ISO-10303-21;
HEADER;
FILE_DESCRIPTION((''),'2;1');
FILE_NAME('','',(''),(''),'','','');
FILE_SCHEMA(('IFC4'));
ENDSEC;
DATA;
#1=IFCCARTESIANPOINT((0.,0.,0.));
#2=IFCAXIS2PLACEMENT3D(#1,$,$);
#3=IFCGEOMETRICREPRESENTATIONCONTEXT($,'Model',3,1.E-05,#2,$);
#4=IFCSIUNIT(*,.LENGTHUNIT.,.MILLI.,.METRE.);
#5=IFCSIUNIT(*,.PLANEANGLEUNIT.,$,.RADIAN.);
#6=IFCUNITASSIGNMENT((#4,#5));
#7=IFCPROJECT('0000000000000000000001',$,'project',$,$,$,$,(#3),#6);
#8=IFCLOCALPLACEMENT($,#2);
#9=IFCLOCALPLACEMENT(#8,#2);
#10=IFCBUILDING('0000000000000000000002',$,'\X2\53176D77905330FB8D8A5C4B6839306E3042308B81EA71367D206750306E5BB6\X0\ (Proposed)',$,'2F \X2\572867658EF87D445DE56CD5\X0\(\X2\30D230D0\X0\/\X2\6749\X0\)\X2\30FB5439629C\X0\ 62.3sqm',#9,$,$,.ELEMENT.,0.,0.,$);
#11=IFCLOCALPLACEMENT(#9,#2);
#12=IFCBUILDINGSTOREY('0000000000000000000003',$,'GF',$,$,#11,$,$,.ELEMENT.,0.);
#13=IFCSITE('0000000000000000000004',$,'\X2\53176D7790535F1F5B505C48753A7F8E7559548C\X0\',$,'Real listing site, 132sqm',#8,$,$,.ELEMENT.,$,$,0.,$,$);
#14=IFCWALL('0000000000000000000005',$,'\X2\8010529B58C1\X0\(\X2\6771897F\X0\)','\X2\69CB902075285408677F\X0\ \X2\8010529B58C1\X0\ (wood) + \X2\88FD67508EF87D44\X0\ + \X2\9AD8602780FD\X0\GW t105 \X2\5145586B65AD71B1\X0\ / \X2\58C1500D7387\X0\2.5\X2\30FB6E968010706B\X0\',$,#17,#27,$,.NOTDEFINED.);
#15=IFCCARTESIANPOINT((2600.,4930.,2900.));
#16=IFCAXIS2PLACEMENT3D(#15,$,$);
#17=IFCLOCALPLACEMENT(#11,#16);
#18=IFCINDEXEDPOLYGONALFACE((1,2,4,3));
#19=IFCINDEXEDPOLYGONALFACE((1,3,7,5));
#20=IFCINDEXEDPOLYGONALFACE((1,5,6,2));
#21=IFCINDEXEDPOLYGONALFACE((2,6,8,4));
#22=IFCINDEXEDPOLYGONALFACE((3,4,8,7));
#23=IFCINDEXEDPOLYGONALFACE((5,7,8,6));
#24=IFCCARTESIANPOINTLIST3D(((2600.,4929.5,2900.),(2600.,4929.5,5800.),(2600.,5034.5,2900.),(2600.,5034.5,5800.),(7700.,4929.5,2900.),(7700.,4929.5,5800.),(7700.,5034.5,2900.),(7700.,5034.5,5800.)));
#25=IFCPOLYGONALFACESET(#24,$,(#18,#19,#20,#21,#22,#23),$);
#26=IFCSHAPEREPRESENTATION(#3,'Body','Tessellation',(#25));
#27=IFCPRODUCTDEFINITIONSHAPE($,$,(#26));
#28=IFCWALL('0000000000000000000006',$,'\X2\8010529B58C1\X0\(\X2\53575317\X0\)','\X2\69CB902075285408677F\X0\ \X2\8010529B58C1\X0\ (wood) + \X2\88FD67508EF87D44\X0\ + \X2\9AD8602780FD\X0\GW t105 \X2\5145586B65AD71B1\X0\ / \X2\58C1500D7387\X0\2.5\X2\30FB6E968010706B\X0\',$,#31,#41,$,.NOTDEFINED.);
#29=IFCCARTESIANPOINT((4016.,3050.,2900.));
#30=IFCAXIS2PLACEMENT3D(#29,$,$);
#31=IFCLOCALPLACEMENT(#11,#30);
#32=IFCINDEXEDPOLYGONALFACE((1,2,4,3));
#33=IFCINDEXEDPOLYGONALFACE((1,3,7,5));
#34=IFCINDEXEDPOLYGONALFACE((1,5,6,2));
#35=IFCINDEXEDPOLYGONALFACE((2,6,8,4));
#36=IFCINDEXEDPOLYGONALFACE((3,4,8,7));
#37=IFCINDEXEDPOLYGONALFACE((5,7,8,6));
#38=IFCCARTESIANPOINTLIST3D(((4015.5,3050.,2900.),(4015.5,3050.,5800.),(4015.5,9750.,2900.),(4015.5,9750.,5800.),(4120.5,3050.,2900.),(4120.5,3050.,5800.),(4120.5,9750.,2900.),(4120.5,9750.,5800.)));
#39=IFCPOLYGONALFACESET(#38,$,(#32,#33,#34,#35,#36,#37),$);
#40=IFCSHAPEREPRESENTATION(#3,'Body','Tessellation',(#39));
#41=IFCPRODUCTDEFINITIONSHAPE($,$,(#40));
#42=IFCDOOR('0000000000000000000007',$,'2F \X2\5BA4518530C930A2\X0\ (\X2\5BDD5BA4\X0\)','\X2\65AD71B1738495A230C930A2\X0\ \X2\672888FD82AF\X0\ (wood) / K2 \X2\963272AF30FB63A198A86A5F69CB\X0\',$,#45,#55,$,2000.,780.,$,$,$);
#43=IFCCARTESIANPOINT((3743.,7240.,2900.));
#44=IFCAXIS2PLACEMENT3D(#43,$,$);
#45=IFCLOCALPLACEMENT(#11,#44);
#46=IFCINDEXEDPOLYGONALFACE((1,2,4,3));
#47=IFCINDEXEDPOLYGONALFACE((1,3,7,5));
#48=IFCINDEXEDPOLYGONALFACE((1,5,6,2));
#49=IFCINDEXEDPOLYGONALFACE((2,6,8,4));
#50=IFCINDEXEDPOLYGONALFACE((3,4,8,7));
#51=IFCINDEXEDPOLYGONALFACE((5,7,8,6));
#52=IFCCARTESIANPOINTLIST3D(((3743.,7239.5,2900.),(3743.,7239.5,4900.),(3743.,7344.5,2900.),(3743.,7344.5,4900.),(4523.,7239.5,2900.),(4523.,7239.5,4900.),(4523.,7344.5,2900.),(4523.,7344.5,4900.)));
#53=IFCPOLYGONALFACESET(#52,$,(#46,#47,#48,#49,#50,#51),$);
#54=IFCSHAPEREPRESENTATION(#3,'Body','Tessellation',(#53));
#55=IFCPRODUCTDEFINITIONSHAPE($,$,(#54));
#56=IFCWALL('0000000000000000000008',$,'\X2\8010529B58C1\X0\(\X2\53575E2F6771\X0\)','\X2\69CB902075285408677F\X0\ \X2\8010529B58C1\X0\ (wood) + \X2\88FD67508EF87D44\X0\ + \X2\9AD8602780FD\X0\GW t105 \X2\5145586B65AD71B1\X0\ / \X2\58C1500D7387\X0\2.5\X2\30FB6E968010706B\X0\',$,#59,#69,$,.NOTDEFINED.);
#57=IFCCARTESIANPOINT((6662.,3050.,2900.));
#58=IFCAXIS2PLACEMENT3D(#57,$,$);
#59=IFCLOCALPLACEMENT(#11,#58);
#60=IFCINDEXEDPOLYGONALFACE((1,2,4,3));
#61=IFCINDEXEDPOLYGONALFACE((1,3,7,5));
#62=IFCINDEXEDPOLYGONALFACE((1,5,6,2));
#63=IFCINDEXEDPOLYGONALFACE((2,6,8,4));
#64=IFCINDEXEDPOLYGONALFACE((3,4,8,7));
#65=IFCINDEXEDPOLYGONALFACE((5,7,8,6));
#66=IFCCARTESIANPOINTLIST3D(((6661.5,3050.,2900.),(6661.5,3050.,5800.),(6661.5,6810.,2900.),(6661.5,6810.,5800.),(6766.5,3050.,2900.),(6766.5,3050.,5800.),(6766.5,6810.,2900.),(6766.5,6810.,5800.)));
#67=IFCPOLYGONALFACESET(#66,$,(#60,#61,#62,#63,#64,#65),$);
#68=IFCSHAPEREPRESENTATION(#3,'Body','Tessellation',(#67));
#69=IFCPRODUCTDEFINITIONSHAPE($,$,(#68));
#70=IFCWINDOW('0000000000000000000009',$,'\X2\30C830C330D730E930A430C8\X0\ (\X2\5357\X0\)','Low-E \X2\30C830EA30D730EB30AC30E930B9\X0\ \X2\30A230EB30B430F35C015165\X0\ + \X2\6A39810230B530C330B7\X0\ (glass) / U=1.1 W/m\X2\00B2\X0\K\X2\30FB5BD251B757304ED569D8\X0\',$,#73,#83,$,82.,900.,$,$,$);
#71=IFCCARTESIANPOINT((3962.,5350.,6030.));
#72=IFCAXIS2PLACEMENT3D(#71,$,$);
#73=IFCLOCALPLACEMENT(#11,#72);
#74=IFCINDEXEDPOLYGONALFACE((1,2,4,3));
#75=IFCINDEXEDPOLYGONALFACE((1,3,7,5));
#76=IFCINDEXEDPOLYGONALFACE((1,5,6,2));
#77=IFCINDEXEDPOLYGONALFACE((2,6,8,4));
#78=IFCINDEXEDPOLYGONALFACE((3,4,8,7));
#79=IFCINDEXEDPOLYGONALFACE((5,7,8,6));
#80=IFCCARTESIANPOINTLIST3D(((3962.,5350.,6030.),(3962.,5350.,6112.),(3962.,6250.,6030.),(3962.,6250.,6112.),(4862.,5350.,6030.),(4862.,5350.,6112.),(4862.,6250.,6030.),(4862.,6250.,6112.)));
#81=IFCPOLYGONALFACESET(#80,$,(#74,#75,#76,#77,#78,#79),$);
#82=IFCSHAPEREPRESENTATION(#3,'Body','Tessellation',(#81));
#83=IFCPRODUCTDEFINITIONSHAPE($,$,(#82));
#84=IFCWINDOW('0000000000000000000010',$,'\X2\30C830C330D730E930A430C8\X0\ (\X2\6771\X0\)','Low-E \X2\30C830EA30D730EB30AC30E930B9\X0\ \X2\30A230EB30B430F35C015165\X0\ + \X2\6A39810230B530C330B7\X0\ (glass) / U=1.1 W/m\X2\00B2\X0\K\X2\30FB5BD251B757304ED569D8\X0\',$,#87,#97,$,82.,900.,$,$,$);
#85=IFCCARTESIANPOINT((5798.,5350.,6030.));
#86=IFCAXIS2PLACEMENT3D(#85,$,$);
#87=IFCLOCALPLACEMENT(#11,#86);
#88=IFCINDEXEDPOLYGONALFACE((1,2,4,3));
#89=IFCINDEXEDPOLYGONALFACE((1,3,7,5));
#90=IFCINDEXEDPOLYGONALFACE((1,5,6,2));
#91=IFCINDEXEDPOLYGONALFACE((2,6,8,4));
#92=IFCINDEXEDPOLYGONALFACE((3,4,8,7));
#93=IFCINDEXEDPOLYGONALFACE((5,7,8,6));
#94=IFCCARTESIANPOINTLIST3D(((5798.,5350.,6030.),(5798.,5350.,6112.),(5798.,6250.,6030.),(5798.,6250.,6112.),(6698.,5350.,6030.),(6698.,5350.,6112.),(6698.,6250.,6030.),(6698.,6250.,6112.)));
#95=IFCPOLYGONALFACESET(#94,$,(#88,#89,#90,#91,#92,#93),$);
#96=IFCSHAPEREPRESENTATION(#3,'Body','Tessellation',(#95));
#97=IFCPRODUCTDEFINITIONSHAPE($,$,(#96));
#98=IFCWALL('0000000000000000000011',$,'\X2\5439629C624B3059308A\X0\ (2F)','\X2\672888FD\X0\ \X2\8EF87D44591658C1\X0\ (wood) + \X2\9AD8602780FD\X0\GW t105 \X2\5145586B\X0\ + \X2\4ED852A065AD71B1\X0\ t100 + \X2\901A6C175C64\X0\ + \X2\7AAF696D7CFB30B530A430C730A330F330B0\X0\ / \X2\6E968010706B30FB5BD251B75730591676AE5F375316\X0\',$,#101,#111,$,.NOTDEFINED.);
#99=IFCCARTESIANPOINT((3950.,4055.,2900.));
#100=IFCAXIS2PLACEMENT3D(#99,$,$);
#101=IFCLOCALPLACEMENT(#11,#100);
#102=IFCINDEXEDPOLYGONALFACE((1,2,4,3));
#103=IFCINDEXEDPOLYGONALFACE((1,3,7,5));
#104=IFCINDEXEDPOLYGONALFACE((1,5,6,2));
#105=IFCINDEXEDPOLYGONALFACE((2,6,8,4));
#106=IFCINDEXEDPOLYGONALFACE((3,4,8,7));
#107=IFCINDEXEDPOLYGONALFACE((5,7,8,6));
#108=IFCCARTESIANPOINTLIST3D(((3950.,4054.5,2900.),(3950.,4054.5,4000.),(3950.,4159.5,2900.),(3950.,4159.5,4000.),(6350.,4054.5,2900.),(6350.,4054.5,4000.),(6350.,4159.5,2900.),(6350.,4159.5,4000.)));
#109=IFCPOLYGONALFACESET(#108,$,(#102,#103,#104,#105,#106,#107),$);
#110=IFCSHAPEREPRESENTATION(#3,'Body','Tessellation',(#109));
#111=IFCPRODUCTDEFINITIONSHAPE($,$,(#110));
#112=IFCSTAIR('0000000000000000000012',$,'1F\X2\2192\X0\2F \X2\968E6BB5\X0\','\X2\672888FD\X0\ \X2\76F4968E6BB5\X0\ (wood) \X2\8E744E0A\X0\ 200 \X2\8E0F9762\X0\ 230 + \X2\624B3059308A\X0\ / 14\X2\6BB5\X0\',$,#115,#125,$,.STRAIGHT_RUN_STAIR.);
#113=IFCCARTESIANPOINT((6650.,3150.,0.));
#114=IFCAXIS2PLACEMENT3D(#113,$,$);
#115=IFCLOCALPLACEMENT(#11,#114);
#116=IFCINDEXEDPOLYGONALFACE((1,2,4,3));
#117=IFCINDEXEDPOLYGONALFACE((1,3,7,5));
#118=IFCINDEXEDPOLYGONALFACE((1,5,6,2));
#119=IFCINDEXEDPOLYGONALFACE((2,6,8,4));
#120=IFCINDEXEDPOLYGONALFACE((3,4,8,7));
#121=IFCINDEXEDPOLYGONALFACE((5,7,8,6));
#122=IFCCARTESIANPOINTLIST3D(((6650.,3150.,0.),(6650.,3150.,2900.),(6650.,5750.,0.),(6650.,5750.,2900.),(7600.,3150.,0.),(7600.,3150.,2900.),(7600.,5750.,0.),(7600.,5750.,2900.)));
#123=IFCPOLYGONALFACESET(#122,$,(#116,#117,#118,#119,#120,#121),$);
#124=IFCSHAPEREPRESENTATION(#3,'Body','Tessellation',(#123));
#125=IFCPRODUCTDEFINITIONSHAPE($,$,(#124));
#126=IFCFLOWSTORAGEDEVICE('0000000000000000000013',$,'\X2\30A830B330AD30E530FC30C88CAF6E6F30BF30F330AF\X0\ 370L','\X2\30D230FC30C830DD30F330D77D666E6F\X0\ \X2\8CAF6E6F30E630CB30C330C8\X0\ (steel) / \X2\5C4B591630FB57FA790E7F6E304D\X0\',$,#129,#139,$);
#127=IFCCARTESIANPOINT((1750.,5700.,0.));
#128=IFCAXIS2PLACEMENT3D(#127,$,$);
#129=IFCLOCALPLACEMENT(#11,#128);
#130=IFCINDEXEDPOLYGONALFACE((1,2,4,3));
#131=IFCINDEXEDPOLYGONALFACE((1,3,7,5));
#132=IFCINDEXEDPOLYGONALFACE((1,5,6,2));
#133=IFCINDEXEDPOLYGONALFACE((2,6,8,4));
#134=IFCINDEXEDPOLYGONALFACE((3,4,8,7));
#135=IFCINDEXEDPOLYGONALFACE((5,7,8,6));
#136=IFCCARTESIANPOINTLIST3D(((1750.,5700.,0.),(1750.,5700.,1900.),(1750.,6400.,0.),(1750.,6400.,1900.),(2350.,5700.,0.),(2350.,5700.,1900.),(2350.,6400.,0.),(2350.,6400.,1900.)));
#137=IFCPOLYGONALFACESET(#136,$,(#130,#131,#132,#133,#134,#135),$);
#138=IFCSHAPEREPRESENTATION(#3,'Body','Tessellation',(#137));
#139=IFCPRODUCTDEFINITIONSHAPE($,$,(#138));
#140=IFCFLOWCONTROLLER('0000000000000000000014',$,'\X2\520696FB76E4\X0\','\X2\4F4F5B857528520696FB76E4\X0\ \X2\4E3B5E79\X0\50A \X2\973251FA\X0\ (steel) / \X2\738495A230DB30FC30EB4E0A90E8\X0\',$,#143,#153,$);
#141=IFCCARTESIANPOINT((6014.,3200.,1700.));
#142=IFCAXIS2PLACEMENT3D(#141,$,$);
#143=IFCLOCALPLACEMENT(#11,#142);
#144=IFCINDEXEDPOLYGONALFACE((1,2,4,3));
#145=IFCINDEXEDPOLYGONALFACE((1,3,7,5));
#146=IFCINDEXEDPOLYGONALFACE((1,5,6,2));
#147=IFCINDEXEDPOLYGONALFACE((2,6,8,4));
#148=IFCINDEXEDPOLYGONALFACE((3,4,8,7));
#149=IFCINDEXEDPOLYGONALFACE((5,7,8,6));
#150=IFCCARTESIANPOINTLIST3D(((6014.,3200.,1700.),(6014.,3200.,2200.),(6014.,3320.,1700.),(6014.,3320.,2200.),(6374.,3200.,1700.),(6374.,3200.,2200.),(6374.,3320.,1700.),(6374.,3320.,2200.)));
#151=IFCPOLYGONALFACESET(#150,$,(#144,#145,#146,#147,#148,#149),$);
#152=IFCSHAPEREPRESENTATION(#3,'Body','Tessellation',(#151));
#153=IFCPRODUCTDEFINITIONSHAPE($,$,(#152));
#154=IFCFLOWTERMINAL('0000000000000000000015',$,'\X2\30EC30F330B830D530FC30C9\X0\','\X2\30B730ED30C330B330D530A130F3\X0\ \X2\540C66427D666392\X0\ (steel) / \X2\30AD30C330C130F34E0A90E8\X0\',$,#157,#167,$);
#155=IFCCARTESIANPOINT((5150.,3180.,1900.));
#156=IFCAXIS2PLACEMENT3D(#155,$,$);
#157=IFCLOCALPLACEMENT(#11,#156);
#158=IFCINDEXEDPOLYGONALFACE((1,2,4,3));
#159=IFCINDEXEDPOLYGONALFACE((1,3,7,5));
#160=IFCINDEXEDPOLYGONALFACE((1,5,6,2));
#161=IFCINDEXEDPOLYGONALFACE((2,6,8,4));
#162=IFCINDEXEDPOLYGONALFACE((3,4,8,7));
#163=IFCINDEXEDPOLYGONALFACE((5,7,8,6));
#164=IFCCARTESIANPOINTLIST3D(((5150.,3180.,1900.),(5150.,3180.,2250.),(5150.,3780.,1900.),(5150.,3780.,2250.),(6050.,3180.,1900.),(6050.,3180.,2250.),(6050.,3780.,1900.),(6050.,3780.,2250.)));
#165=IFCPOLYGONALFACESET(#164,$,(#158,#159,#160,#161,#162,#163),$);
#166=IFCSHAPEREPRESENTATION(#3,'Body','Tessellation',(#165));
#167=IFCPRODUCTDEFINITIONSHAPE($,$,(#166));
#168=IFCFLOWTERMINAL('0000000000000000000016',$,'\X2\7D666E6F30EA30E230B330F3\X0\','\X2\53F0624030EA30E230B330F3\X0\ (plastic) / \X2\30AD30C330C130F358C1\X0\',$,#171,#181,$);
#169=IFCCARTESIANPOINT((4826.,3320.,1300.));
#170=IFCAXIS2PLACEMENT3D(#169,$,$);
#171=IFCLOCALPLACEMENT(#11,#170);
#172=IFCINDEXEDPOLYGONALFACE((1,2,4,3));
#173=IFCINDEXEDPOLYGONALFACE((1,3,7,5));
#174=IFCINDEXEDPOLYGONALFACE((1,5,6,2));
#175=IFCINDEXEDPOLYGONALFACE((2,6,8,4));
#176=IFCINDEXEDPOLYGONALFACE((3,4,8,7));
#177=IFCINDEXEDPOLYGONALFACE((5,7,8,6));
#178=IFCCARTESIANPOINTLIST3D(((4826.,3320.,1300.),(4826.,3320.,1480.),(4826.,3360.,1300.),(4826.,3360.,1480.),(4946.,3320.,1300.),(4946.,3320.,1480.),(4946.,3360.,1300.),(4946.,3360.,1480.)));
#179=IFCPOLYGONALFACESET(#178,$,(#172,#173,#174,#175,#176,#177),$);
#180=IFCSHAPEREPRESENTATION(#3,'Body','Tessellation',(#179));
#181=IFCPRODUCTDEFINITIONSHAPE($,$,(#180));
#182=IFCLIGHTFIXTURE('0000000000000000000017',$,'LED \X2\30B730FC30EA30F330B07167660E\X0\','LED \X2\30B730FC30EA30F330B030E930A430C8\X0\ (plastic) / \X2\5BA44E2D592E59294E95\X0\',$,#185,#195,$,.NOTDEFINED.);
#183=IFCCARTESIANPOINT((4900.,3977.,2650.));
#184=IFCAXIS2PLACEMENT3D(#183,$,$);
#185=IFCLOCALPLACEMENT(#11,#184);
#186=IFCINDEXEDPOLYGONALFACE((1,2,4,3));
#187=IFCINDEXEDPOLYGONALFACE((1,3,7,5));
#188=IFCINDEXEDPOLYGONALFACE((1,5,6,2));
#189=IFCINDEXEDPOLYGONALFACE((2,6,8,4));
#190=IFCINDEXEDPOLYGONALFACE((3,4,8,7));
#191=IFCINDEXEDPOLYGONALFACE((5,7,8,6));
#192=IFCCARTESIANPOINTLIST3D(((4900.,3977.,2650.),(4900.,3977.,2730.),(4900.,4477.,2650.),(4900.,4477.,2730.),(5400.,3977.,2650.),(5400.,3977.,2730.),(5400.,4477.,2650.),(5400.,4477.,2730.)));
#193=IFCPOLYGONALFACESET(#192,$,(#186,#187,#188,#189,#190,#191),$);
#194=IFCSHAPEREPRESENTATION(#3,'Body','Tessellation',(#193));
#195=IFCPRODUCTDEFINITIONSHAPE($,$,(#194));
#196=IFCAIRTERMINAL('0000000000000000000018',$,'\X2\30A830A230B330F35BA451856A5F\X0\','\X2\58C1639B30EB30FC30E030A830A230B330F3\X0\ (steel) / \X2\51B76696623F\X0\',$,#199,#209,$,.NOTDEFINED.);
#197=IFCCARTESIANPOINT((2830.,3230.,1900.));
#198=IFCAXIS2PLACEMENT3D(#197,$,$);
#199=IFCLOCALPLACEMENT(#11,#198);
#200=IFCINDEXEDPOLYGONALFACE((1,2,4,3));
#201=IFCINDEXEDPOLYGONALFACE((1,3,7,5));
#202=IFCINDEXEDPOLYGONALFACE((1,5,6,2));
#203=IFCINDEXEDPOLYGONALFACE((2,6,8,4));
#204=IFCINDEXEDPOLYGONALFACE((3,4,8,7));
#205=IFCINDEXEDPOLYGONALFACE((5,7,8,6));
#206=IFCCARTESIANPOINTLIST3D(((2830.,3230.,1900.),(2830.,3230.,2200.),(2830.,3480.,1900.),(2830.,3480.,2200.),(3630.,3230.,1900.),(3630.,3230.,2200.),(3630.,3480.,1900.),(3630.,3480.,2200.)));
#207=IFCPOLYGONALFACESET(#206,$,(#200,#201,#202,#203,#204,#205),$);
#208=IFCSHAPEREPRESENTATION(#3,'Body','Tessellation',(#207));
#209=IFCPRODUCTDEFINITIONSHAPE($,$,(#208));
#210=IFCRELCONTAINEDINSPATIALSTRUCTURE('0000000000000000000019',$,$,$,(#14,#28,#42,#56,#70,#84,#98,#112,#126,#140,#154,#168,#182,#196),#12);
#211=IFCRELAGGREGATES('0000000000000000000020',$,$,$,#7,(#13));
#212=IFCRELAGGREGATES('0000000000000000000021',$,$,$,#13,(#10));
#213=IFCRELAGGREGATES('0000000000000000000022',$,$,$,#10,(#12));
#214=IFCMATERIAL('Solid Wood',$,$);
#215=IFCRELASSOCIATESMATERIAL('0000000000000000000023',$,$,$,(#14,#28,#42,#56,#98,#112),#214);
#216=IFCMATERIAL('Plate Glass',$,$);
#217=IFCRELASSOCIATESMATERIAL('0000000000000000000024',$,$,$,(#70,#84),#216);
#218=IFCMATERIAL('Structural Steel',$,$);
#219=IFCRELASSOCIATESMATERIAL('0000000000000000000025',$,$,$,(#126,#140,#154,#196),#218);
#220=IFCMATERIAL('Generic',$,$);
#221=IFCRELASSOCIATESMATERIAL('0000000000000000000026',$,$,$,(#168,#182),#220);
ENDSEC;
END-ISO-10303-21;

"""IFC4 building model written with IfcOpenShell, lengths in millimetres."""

from ifc_helpers import new_model, si_unit, frame, frame_2d, origin, place, context, project, spatial, rectangle, extrude, material, element, fill, save


model = new_model("IFC4")

# Units and contexts
model_context = context("Model", 3, precision=1e-05, world=origin())
ifc_project = project(units=[si_unit("LENGTHUNIT", "METRE", prefix="MILLI"), si_unit("PLANEANGLEUNIT", "RADIAN")], contexts=[model_context])

# Site, building, storey
site_placement = place(None, origin())
site = spatial("IfcSite", under=ifc_project, at=site_placement, Name="北海道弟子屈町美留和", ObjectType="Real listing site, 132sqm", CompositionType="ELEMENT", RefElevation=0.0)
building_placement = place(site_placement, origin())
building = spatial("IfcBuilding", under=site, at=building_placement, Name="北海道・越屋根のある自然素材の家 (Proposed)", ObjectType="2F 在来軸組工法(ヒバ/杉)・吹抜 62.3sqm", CompositionType="ELEMENT", ElevationOfRefHeight=0.0, ElevationOfTerrain=0.0)
storey_placement = place(building_placement, origin())
storey = spatial("IfcBuildingStorey", under=building, at=storey_placement, Name="GF", CompositionType="ELEMENT", Elevation=0.0)

# Shared definitions
ifc_material_1 = material(Name="Solid Wood")

# Wall
wall_1_placement = place(storey_placement, frame((2600.0, 4930.0, 2900.0)))
element("IfcWall", 1, at=wall_1_placement, inside=storey, material=ifc_material_1, Name="耐力壁(東西)", Description="構造用合板 耐力壁 (wood) + 製材軸組 + 高性能GW t105 充填断熱 / 壁倍率2.5・準耐火", PredefinedType="NOTDEFINED", context=model_context, shape_type="SweptSolid", body=[
    extrude(rectangle(XDim=5100.0, YDim=105.0, at=frame_2d((2550.0, 52.0))), frame((2600.0, 4930.0, 2900.0)), (0.0, 0.0, 1.0), 2900.0),
])

# Wall, opening, door
wall_2_placement = place(storey_placement, frame((4016.0, 3050.0, 2900.0)))
wall_2 = element("IfcWall", 2, at=wall_2_placement, inside=storey, material=ifc_material_1, Name="耐力壁(南北)", Description="構造用合板 耐力壁 (wood) + 製材軸組 + 高性能GW t105 充填断熱 / 壁倍率2.5・準耐火", PredefinedType="NOTDEFINED", context=model_context, shape_type="SweptSolid", body=[
    extrude(rectangle(XDim=105.0, YDim=6700.0, at=frame_2d((52.0, 3350.0))), frame((4016.0, 3050.0, 2900.0)), (0.0, 0.0, 1.0), 2900.0),
])
opening_placement = place(storey_placement, frame((3743.0, 7240.0, 2900.0)))
opening = element("IfcOpeningElement", 3, at=opening_placement, cuts=wall_2, PredefinedType="NOTDEFINED", context=model_context, shape_type="SweptSolid", body=[
    extrude(rectangle(XDim=780.0, YDim=105.0, at=frame_2d((390.0, 52.0))), frame((3743.0, 7240.0, 2900.0)), (0.0, 0.0, 1.0), 2000.0),
])
door_placement = place(storey_placement, frame((3743.0, 7240.0, 2900.0)))
door = element("IfcDoor", 4, at=door_placement, inside=storey, material=ifc_material_1, Name="2F 室内ドア (寝室)", Description="断熱玄関ドア 木製芯 (wood) / K2 防犯・採風機構", OverallHeight=2000.0, OverallWidth=780.0, context=model_context, shape_type="SweptSolid", body=[
    extrude(rectangle(XDim=780.0, YDim=105.0, at=frame_2d((390.0, 52.0))), frame((3743.0, 7240.0, 2900.0)), (0.0, 0.0, 1.0), 2000.0),
])
fill(opening, door)

# Wall
wall_3_placement = place(storey_placement, frame((6662.0, 3050.0, 2900.0)))
element("IfcWall", 5, at=wall_3_placement, inside=storey, material=ifc_material_1, Name="耐力壁(南帯東)", Description="構造用合板 耐力壁 (wood) + 製材軸組 + 高性能GW t105 充填断熱 / 壁倍率2.5・準耐火", PredefinedType="NOTDEFINED", context=model_context, shape_type="SweptSolid", body=[
    extrude(rectangle(XDim=105.0, YDim=3760.0, at=frame_2d((52.0, 1880.0))), frame((6662.0, 3050.0, 2900.0)), (0.0, 0.0, 1.0), 2900.0),
])

# Windows
ifc_material_2 = material(Name="Plate Glass")
window_1_placement = place(storey_placement, frame((3962.0, 5350.0, 6030.0)))
element("IfcWindow", 6, at=window_1_placement, inside=storey, material=ifc_material_2, Name="トップライト (南)", Description="Low-E トリプルガラス アルゴン封入 + 樹脂サッシ (glass) / U=1.1 W/m²K・寒冷地仕様", OverallHeight=82.0, OverallWidth=900.0, context=model_context, shape_type="SweptSolid", body=[
    extrude(rectangle(XDim=900.0, YDim=900.0, at=frame_2d((450.0, 450.0))), frame((3962.0, 5350.0, 6030.0)), (0.0, 0.0, 1.0), 82.0),
])
window_2_placement = place(storey_placement, frame((5798.0, 5350.0, 6030.0)))
element("IfcWindow", 7, at=window_2_placement, inside=storey, material=ifc_material_2, Name="トップライト (東)", Description="Low-E トリプルガラス アルゴン封入 + 樹脂サッシ (glass) / U=1.1 W/m²K・寒冷地仕様", OverallHeight=82.0, OverallWidth=900.0, context=model_context, shape_type="SweptSolid", body=[
    extrude(rectangle(XDim=900.0, YDim=900.0, at=frame_2d((450.0, 450.0))), frame((5798.0, 5350.0, 6030.0)), (0.0, 0.0, 1.0), 82.0),
])

# Wall
wall_4_placement = place(storey_placement, frame((3950.0, 4055.0, 2900.0)))
element("IfcWall", 8, at=wall_4_placement, inside=storey, material=ifc_material_1, Name="吹抜手すり (2F)", Description="木製 軸組外壁 (wood) + 高性能GW t105 充填 + 付加断熱 t100 + 通気層 + 窯業系サイディング / 準耐火・寒冷地外皮強化", PredefinedType="NOTDEFINED", context=model_context, shape_type="SweptSolid", body=[
    extrude(rectangle(XDim=2400.0, YDim=105.0, at=frame_2d((1200.0, 52.0))), frame((3950.0, 4055.0, 2900.0)), (0.0, 0.0, 1.0), 1100.0),
])

# Stair
stair_placement = place(storey_placement, frame((6650.0, 3150.0, 0.0)))
element("IfcStair", 9, at=stair_placement, inside=storey, material=ifc_material_1, Name="1F→2F 階段", Description="木製 直階段 (wood) 蹴上 200 踏面 230 + 手すり / 14段", PredefinedType="STRAIGHT_RUN_STAIR", context=model_context, shape_type="SweptSolid", body=[
    extrude(rectangle(XDim=950.0, YDim=2600.0, at=frame_2d((475.0, 1300.0))), frame((6650.0, 3150.0, 0.0)), (0.0, 0.0, 1.0), 2900.0),
])

# Flow storage device
ifc_material_3 = material(Name="Structural Steel")
flow_storage_device_placement = place(storey_placement, frame((1750.0, 5700.0, 0.0)))
element("IfcFlowStorageDevice", 10, at=flow_storage_device_placement, inside=storey, material=ifc_material_3, Name="エコキュート貯湯タンク 370L", Description="ヒートポンプ給湯 貯湯ユニット (steel) / 屋外・基礎置き", context=model_context, shape_type="SweptSolid", body=[
    extrude(rectangle(XDim=600.0, YDim=700.0, at=frame_2d((300.0, 350.0))), frame((1750.0, 5700.0, 0.0)), (0.0, 0.0, 1.0), 1900.0),
])

# Flow controller
flow_controller_placement = place(storey_placement, frame((6014.0, 3200.0, 1700.0)))
element("IfcFlowController", 11, at=flow_controller_placement, inside=storey, material=ifc_material_3, Name="分電盤", Description="住宅用分電盤 主幹50A 露出 (steel) / 玄関ホール上部", context=model_context, shape_type="SweptSolid", body=[
    extrude(rectangle(XDim=360.0, YDim=120.0, at=frame_2d((180.0, 60.0))), frame((6014.0, 3200.0, 1700.0)), (0.0, 0.0, 1.0), 500.0),
])

# Flow terminals
flow_terminal_1_placement = place(storey_placement, frame((5150.0, 3180.0, 1900.0)))
element("IfcFlowTerminal", 12, at=flow_terminal_1_placement, inside=storey, material=ifc_material_3, Name="レンジフード", Description="シロッコファン 同時給排 (steel) / キッチン上部", context=model_context, shape_type="SweptSolid", body=[
    extrude(rectangle(XDim=900.0, YDim=600.0, at=frame_2d((450.0, 300.0))), frame((5150.0, 3180.0, 1900.0)), (0.0, 0.0, 1.0), 350.0),
])
ifc_material_4 = material(Name="Generic")
flow_terminal_2_placement = place(storey_placement, frame((4826.0, 3320.0, 1300.0)))
element("IfcFlowTerminal", 13, at=flow_terminal_2_placement, inside=storey, material=ifc_material_4, Name="給湯リモコン", Description="台所リモコン (plastic) / キッチン壁", context=model_context, shape_type="SweptSolid", body=[
    extrude(rectangle(XDim=120.0, YDim=40.0, at=frame_2d((60.0, 20.0))), frame((4826.0, 3320.0, 1300.0)), (0.0, 0.0, 1.0), 180.0),
])

# Light fixture
light_fixture_1_placement = place(storey_placement, frame((4900.0, 3977.0, 2650.0)))
element("IfcLightFixture", 14, at=light_fixture_1_placement, inside=storey, material=ifc_material_4, Name="LED シーリング照明", Description="LED シーリングライト (plastic) / 室中央天井", PredefinedType="NOTDEFINED", context=model_context, shape_type="SweptSolid", body=[
    extrude(rectangle(XDim=500.0, YDim=500.0, at=frame_2d((250.0, 250.0))), frame((4900.0, 3977.0, 2650.0)), (0.0, 0.0, 1.0), 80.0),
])

# Air terminal
air_terminal_1_placement = place(storey_placement, frame((2830.0, 3230.0, 1900.0)))
element("IfcAirTerminal", 15, at=air_terminal_1_placement, inside=storey, material=ifc_material_3, Name="エアコン室内機", Description="壁掛ルームエアコン (steel) / 冷暖房", PredefinedType="NOTDEFINED", context=model_context, shape_type="SweptSolid", body=[
    extrude(rectangle(XDim=800.0, YDim=250.0, at=frame_2d((400.0, 125.0))), frame((2830.0, 3230.0, 1900.0)), (0.0, 0.0, 1.0), 300.0),
])

save(model, "model.ifc")
